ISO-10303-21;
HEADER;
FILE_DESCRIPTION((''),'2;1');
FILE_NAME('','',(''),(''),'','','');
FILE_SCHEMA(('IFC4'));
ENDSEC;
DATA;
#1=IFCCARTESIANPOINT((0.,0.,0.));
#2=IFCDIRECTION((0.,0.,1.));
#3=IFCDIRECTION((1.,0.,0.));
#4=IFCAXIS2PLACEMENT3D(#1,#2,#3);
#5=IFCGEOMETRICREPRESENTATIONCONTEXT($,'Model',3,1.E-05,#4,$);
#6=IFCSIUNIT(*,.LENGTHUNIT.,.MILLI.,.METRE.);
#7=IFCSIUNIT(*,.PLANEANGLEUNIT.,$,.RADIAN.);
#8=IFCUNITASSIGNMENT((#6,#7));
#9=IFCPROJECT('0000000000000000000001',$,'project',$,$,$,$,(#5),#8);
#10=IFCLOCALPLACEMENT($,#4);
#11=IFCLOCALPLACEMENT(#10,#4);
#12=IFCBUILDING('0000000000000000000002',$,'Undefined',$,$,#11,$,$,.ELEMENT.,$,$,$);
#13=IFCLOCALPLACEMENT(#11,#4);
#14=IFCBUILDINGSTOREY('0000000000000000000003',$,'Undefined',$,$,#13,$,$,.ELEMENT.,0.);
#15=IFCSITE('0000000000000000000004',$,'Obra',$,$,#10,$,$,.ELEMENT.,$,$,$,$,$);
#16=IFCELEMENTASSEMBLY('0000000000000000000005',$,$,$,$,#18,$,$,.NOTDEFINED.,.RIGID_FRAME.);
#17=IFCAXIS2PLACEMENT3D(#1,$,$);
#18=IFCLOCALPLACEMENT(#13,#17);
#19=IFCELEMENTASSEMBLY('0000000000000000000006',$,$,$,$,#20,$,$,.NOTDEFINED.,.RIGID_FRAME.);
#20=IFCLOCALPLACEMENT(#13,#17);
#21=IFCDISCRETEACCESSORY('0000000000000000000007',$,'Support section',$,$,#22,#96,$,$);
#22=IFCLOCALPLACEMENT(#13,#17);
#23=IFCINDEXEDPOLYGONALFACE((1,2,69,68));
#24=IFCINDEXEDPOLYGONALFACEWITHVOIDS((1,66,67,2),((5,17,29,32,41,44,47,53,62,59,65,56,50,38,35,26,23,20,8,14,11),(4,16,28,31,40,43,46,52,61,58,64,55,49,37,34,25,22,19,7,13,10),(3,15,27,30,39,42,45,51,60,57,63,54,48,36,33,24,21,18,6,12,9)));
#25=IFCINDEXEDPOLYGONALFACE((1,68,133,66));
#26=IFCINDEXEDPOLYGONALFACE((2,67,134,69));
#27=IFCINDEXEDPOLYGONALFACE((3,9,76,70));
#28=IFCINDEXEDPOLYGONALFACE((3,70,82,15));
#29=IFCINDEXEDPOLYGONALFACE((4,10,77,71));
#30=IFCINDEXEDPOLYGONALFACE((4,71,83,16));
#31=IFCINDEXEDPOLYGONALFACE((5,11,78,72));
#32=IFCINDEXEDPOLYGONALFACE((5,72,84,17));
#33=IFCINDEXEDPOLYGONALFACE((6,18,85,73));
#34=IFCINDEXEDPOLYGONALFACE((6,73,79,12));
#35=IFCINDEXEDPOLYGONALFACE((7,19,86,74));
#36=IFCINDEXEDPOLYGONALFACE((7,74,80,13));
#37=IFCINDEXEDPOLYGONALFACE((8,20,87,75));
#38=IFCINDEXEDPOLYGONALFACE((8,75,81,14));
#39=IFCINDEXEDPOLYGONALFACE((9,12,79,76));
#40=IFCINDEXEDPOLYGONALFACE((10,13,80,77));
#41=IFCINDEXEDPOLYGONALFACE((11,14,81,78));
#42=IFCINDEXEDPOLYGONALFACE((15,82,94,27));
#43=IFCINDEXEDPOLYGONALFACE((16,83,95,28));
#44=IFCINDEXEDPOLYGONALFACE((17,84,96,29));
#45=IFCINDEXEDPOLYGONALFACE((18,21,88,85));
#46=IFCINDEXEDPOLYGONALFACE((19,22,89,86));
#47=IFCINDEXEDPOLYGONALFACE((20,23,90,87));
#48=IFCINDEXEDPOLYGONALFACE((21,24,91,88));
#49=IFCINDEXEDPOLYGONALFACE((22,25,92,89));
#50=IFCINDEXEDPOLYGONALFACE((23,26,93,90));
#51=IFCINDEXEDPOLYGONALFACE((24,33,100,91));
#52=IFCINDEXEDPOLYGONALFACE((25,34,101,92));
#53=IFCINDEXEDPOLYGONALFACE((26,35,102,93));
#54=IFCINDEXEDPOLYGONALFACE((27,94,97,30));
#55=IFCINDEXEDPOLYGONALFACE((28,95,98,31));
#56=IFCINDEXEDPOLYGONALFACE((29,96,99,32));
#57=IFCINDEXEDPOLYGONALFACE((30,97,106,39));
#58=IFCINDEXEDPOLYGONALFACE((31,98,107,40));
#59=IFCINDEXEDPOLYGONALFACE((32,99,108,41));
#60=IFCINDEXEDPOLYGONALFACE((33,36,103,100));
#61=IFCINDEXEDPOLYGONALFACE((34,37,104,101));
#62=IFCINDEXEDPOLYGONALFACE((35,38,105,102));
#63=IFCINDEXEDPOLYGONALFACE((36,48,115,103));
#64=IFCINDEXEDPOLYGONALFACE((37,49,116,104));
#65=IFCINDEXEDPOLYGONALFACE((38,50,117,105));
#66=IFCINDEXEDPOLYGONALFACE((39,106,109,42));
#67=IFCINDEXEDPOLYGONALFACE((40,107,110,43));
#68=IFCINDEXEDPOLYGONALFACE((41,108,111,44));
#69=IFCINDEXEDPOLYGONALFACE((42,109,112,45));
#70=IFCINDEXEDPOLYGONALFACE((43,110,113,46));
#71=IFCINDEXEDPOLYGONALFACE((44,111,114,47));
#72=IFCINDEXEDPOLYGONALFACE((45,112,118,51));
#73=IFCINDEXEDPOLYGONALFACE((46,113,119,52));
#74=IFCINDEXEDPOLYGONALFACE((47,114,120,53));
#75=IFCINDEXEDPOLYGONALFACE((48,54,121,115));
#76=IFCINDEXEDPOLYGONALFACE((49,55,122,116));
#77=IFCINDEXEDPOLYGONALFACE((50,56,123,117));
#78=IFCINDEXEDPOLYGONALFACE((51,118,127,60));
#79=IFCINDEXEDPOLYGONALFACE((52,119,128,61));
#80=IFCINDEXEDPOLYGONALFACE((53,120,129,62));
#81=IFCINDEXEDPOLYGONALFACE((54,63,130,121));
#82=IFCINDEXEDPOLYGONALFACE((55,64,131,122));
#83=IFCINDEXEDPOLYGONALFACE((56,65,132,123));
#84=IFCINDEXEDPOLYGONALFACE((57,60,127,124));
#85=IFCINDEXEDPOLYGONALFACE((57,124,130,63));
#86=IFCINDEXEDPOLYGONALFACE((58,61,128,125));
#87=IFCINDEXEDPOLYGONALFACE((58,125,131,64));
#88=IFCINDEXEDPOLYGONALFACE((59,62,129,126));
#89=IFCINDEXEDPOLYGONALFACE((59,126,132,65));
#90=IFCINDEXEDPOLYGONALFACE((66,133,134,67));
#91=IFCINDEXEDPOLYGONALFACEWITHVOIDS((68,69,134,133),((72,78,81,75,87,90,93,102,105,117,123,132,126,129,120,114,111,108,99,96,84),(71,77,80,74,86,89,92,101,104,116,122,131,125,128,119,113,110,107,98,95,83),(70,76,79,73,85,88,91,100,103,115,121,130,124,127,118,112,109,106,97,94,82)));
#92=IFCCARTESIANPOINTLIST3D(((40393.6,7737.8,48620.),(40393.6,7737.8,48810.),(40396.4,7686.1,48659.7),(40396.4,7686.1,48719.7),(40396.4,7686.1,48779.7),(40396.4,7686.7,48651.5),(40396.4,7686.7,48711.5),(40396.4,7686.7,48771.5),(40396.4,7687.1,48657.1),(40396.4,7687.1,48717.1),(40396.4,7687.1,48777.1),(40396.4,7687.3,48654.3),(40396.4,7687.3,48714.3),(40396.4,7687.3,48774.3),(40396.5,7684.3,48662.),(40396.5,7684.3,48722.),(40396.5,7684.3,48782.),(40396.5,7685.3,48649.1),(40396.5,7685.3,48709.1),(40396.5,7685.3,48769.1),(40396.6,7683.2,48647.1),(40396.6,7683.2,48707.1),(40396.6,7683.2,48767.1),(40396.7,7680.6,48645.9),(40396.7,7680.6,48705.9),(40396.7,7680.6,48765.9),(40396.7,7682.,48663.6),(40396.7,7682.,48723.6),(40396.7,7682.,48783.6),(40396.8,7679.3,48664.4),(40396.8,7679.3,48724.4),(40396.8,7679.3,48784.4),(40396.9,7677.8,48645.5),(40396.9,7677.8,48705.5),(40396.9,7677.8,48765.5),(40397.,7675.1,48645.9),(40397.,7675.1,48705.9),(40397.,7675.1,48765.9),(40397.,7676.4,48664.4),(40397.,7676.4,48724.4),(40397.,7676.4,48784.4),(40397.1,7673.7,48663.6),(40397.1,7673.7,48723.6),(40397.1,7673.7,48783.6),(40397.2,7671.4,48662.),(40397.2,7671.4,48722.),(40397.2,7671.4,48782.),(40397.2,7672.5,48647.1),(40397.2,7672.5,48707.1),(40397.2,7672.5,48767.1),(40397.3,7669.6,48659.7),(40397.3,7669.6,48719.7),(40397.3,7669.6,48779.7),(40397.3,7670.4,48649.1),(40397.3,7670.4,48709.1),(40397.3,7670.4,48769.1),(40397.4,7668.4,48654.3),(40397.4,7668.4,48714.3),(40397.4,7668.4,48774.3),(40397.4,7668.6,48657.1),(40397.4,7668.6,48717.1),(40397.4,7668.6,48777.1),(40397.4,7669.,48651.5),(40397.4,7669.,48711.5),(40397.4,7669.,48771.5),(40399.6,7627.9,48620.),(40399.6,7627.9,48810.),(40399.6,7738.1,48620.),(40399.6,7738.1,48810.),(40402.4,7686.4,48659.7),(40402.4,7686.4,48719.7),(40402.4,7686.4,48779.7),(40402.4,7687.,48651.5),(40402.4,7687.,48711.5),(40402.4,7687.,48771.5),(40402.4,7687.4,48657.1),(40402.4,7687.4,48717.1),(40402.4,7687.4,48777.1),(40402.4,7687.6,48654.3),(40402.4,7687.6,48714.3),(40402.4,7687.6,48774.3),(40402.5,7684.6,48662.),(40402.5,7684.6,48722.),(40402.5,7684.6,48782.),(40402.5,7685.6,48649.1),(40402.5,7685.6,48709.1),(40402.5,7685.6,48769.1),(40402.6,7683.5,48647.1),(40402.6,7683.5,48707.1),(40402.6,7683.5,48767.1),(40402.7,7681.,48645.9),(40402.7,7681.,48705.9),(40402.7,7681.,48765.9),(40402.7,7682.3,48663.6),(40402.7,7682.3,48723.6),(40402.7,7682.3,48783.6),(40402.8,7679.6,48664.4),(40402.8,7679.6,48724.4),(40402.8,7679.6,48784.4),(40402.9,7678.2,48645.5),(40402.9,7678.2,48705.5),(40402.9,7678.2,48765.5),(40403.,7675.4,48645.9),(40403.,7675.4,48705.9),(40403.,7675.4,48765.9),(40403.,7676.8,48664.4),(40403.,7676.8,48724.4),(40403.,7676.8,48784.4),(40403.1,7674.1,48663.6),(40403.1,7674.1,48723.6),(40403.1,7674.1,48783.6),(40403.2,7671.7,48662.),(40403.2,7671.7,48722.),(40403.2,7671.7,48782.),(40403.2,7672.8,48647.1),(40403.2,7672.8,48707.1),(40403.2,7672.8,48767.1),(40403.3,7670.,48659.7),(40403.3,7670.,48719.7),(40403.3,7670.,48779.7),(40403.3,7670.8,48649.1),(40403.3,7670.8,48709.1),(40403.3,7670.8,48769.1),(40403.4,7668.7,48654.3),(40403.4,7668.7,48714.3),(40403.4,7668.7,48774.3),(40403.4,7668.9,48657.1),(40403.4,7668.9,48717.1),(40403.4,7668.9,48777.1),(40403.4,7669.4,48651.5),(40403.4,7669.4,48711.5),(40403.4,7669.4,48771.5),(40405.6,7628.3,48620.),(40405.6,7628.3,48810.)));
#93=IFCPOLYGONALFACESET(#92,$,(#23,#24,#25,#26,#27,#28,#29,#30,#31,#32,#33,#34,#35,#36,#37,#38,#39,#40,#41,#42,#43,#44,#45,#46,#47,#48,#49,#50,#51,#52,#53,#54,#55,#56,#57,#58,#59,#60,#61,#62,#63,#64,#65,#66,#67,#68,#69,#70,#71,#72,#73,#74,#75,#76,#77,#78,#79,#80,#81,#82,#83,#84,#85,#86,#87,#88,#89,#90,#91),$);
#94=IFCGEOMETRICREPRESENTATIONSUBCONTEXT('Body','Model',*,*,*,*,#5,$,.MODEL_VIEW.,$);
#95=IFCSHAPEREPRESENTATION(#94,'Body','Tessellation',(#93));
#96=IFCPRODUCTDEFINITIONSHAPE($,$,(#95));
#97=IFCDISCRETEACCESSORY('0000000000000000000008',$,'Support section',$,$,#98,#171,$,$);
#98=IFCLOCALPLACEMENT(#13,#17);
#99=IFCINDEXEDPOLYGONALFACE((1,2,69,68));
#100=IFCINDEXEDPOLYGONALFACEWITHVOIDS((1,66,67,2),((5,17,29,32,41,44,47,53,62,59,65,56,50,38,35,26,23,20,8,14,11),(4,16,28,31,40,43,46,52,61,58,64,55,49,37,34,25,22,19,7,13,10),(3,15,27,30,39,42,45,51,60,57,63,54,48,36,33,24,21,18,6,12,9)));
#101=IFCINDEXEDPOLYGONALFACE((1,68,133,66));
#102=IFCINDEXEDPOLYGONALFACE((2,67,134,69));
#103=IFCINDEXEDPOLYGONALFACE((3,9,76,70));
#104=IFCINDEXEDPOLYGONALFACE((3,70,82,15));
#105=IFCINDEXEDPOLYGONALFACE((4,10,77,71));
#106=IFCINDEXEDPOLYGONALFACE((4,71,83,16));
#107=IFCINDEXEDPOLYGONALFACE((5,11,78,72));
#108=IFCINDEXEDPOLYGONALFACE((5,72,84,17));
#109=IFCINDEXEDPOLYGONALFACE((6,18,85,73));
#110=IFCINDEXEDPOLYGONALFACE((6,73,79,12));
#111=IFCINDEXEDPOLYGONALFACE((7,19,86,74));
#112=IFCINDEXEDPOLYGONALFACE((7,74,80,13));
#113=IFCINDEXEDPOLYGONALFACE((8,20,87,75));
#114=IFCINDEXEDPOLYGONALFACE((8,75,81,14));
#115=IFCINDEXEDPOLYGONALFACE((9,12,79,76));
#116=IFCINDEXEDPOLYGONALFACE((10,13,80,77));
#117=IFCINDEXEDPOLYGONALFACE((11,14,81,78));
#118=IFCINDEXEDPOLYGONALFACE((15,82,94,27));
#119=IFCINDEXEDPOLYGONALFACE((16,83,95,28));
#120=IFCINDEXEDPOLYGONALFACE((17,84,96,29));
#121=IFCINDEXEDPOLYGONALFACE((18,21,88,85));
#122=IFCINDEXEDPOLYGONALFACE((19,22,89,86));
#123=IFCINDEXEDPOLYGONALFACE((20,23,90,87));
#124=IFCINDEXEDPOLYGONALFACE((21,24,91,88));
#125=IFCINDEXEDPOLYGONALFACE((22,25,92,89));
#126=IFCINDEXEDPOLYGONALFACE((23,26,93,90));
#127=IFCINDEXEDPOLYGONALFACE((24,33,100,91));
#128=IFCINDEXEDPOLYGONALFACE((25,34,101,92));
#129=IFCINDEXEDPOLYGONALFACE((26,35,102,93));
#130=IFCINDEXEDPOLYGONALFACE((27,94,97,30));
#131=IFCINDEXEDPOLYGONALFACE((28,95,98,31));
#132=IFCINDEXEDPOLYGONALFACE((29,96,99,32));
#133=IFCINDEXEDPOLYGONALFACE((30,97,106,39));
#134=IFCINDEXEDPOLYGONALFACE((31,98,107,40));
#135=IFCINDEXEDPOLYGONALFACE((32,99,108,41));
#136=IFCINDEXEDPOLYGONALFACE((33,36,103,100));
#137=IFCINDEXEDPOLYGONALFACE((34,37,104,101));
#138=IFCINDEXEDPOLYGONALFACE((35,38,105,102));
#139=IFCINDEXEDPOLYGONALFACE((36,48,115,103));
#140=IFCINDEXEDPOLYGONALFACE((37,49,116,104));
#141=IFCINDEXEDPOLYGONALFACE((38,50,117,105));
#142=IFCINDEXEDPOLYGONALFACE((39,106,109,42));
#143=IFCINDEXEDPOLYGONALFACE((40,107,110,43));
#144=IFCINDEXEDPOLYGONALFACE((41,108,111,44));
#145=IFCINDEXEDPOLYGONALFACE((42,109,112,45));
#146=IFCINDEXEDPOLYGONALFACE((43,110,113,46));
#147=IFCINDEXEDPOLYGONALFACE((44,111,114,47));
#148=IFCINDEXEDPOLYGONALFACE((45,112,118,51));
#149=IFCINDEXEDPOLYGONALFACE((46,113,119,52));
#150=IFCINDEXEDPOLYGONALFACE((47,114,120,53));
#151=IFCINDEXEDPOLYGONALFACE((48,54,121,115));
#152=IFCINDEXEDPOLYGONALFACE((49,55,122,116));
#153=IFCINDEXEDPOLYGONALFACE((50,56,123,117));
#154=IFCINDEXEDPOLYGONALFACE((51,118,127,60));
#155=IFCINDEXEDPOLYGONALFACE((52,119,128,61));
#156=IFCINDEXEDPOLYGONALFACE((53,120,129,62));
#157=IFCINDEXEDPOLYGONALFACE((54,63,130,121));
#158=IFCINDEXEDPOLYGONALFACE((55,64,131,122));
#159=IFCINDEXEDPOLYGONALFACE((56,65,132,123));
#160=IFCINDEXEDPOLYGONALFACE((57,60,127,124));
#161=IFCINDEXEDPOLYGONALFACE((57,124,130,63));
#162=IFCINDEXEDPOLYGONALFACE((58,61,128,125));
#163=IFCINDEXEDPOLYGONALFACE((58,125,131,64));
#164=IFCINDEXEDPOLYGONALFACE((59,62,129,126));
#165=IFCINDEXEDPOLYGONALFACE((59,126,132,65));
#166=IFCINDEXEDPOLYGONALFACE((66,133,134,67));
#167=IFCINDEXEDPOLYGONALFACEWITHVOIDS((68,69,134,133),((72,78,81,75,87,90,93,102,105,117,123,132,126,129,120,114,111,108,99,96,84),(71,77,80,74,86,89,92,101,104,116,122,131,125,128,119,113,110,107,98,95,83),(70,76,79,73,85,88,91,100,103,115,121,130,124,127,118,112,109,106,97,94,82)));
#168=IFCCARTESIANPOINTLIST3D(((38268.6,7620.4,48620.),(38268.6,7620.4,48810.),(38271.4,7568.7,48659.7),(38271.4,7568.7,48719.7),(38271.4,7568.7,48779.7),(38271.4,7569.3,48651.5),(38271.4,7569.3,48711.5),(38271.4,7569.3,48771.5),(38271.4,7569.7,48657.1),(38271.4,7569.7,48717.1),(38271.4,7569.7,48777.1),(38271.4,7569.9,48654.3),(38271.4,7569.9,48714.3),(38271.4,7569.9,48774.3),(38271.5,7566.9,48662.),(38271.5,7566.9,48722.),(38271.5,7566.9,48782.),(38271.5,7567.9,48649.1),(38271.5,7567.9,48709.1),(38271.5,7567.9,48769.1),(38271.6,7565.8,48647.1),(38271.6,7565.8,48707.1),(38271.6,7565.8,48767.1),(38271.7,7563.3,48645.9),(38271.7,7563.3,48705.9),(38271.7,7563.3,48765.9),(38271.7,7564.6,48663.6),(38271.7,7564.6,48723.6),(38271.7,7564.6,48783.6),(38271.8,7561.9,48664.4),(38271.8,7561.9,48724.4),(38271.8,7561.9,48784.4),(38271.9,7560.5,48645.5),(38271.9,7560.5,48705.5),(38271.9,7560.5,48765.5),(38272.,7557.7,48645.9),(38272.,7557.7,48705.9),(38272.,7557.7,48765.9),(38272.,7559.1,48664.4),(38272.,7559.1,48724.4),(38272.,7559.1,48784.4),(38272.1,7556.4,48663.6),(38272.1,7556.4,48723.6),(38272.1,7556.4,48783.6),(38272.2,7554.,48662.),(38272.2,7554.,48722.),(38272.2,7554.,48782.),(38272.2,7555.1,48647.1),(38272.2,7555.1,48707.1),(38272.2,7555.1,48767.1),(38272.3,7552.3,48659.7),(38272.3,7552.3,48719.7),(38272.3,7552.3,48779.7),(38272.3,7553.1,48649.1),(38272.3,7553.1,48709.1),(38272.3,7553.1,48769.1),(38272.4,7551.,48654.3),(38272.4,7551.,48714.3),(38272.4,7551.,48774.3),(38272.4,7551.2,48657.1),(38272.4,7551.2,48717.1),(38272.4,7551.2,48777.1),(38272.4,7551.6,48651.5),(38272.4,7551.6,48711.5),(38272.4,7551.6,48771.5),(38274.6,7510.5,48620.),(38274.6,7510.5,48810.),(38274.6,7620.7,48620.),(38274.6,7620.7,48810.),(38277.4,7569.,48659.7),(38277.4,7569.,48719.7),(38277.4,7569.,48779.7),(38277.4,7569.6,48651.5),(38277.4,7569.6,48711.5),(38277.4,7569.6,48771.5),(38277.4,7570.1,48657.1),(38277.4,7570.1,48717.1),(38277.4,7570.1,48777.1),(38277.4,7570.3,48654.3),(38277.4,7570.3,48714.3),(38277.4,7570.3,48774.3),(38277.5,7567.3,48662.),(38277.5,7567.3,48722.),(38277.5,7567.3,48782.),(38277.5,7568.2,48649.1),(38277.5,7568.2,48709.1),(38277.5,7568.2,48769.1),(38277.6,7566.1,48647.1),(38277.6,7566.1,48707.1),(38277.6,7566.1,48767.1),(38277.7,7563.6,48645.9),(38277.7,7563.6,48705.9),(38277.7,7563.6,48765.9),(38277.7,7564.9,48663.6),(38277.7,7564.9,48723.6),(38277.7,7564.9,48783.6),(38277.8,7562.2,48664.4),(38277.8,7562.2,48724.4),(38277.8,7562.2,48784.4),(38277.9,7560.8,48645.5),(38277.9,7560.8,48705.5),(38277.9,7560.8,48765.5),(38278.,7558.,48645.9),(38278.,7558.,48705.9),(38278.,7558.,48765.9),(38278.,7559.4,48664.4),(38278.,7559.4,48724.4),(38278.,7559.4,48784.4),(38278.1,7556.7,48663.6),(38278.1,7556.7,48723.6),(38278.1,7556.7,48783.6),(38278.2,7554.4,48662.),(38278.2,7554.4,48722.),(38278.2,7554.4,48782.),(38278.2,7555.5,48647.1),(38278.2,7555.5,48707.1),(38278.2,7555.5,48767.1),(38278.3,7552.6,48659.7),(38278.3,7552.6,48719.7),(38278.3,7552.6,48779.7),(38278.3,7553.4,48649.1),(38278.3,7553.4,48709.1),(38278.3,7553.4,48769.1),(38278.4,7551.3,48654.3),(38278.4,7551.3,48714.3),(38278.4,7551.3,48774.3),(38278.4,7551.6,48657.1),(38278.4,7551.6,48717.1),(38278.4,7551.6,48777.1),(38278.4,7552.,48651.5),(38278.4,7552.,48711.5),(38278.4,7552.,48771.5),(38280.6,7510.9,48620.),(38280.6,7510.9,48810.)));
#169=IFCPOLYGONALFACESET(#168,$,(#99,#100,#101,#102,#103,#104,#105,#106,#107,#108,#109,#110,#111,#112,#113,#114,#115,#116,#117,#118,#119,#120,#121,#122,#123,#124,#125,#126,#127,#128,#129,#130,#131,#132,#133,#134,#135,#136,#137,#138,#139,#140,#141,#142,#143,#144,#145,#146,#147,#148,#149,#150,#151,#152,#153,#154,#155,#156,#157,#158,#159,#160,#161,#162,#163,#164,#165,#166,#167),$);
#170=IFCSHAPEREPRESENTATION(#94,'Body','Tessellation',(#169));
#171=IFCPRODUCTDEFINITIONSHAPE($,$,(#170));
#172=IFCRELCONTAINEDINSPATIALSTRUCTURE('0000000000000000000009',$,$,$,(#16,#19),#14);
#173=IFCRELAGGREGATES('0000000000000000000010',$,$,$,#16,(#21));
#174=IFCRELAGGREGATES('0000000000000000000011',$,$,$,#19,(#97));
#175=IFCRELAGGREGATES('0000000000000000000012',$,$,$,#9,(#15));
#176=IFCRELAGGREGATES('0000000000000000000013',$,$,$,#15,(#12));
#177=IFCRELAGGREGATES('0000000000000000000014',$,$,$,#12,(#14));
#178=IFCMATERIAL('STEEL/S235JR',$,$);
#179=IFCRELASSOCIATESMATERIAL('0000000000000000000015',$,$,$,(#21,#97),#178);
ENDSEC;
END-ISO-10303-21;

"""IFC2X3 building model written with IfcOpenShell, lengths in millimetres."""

from ifc_helpers import new_model, si_unit, frame, origin_with_axes, origin_2d_with_axis, place, context, subcontext, project, spatial, rectangle, circle, extrude, source, transform, mapped, material, element, aggregate, save


model = new_model("IFC2X3")

# Units and contexts
model_context = context("Model", 3, precision=1e-05, world=origin_with_axes())
body_context = subcontext(model_context, "Body", "Model", "MODEL_VIEW")
ifc_project = project(units=[si_unit("LENGTHUNIT", "METRE", prefix="MILLI"), si_unit("PLANEANGLEUNIT", "RADIAN")], contexts=[model_context])

# Site, building, storey
site_placement = place(None, origin_with_axes())
site = spatial("IfcSite", under=ifc_project, at=site_placement, Name="Obra", CompositionType="ELEMENT")
building_placement = place(site_placement, origin_with_axes())
building = spatial("IfcBuilding", under=site, at=building_placement, Name="Undefined", CompositionType="ELEMENT")
storey_placement = place(building_placement, origin_with_axes())
storey = spatial("IfcBuildingStorey", under=building, at=storey_placement, Name="Undefined", CompositionType="ELEMENT", Elevation=0.0)

# Element assemblies
assembly_1_placement = place(storey_placement, origin_with_axes())
assembly_1 = element("IfcElementAssembly", 1, at=assembly_1_placement, inside=storey, AssemblyPlace="NOTDEFINED", PredefinedType="RIGID_FRAME")
ifc_material_1 = material(Name="STEEL/S235JR")
assembly_2_placement = place(storey_placement, origin_with_axes())
assembly_2 = element("IfcElementAssembly", 2, at=assembly_2_placement, inside=storey, AssemblyPlace="NOTDEFINED", PredefinedType="RIGID_FRAME")

# Discrete accessories, openings
discrete_accessory_1_placement = place(assembly_1_placement, frame((40399.6, 7683.0, 48620.0), z_axis=(0.0, 0.0, 1.0), x_axis=(-0.055152, 0.998478, 0.0)))
discrete_accessory_1 = element("IfcDiscreteAccessory", 3, at=discrete_accessory_1_placement, material=ifc_material_1, Name="Support section", context=body_context, shape_type="SweptSolid", body=[
    extrude(rectangle(XDim=6.0, YDim=110.0, at=origin_2d_with_axis()), frame((0.0, 0.0, 190.0), z_axis=(0.0, 0.0, -1.0), x_axis=(0.0, 1.0, 0.0)), (0.0, 0.0, 1.0), 190.0),
])
shared_shape_1 = source(origin_with_axes(), body_context, "Body", "SweptSolid", [
    extrude(circle(Radius=9.5, at=origin_2d_with_axis()), frame((0.0, -9.2, 0.0), z_axis=(0.0, 1.0, 0.0), x_axis=(1.0, 0.0, 0.0)), (0.0, 0.0, 1.0), 6.2),
])
opening_1_placement = place(assembly_1_placement, frame((40403.2, 7728.3, 48835.0), z_axis=(0.055152, -0.998478, 0.0), x_axis=(0.0, 0.0, -1.0)))
element("IfcOpeningElement", 4, at=opening_1_placement, cuts=discrete_accessory_1, ObjectType="Opening", context=body_context, shape_type="MappedRepresentation", body=[
    mapped(shared_shape_1, transform((60.0, 0.0, 50.0))),
    mapped(shared_shape_1, transform((120.0, 0.0, 50.0))),
    mapped(shared_shape_1, transform((180.0, 0.0, 50.0))),
])
aggregate(assembly_1, [discrete_accessory_1])
discrete_accessory_2_placement = place(assembly_2_placement, frame((38274.6, 7565.6, 48620.0), z_axis=(0.0, 0.0, 1.0), x_axis=(-0.055152, 0.998478, 0.0)))
discrete_accessory_2 = element("IfcDiscreteAccessory", 5, at=discrete_accessory_2_placement, material=ifc_material_1, Name="Support section", context=body_context, shape_type="SweptSolid", body=[
    extrude(rectangle(XDim=6.0, YDim=110.0, at=origin_2d_with_axis()), frame((0.0, 0.0, 190.0), z_axis=(0.0, 0.0, -1.0), x_axis=(0.0, 1.0, 0.0)), (0.0, 0.0, 1.0), 190.0),
])
opening_2_placement = place(assembly_2_placement, frame((38278.2, 7610.9, 48835.0), z_axis=(0.055152, -0.998478, 0.0), x_axis=(0.0, 0.0, -1.0)))
element("IfcOpeningElement", 6, at=opening_2_placement, cuts=discrete_accessory_2, ObjectType="Opening", context=body_context, shape_type="MappedRepresentation", body=[
    mapped(shared_shape_1, transform((60.0, 0.0, 50.0))),
    mapped(shared_shape_1, transform((120.0, 0.0, 50.0))),
    mapped(shared_shape_1, transform((180.0, 0.0, 50.0))),
])
aggregate(assembly_2, [discrete_accessory_2])

save(model, "model.ifc")
